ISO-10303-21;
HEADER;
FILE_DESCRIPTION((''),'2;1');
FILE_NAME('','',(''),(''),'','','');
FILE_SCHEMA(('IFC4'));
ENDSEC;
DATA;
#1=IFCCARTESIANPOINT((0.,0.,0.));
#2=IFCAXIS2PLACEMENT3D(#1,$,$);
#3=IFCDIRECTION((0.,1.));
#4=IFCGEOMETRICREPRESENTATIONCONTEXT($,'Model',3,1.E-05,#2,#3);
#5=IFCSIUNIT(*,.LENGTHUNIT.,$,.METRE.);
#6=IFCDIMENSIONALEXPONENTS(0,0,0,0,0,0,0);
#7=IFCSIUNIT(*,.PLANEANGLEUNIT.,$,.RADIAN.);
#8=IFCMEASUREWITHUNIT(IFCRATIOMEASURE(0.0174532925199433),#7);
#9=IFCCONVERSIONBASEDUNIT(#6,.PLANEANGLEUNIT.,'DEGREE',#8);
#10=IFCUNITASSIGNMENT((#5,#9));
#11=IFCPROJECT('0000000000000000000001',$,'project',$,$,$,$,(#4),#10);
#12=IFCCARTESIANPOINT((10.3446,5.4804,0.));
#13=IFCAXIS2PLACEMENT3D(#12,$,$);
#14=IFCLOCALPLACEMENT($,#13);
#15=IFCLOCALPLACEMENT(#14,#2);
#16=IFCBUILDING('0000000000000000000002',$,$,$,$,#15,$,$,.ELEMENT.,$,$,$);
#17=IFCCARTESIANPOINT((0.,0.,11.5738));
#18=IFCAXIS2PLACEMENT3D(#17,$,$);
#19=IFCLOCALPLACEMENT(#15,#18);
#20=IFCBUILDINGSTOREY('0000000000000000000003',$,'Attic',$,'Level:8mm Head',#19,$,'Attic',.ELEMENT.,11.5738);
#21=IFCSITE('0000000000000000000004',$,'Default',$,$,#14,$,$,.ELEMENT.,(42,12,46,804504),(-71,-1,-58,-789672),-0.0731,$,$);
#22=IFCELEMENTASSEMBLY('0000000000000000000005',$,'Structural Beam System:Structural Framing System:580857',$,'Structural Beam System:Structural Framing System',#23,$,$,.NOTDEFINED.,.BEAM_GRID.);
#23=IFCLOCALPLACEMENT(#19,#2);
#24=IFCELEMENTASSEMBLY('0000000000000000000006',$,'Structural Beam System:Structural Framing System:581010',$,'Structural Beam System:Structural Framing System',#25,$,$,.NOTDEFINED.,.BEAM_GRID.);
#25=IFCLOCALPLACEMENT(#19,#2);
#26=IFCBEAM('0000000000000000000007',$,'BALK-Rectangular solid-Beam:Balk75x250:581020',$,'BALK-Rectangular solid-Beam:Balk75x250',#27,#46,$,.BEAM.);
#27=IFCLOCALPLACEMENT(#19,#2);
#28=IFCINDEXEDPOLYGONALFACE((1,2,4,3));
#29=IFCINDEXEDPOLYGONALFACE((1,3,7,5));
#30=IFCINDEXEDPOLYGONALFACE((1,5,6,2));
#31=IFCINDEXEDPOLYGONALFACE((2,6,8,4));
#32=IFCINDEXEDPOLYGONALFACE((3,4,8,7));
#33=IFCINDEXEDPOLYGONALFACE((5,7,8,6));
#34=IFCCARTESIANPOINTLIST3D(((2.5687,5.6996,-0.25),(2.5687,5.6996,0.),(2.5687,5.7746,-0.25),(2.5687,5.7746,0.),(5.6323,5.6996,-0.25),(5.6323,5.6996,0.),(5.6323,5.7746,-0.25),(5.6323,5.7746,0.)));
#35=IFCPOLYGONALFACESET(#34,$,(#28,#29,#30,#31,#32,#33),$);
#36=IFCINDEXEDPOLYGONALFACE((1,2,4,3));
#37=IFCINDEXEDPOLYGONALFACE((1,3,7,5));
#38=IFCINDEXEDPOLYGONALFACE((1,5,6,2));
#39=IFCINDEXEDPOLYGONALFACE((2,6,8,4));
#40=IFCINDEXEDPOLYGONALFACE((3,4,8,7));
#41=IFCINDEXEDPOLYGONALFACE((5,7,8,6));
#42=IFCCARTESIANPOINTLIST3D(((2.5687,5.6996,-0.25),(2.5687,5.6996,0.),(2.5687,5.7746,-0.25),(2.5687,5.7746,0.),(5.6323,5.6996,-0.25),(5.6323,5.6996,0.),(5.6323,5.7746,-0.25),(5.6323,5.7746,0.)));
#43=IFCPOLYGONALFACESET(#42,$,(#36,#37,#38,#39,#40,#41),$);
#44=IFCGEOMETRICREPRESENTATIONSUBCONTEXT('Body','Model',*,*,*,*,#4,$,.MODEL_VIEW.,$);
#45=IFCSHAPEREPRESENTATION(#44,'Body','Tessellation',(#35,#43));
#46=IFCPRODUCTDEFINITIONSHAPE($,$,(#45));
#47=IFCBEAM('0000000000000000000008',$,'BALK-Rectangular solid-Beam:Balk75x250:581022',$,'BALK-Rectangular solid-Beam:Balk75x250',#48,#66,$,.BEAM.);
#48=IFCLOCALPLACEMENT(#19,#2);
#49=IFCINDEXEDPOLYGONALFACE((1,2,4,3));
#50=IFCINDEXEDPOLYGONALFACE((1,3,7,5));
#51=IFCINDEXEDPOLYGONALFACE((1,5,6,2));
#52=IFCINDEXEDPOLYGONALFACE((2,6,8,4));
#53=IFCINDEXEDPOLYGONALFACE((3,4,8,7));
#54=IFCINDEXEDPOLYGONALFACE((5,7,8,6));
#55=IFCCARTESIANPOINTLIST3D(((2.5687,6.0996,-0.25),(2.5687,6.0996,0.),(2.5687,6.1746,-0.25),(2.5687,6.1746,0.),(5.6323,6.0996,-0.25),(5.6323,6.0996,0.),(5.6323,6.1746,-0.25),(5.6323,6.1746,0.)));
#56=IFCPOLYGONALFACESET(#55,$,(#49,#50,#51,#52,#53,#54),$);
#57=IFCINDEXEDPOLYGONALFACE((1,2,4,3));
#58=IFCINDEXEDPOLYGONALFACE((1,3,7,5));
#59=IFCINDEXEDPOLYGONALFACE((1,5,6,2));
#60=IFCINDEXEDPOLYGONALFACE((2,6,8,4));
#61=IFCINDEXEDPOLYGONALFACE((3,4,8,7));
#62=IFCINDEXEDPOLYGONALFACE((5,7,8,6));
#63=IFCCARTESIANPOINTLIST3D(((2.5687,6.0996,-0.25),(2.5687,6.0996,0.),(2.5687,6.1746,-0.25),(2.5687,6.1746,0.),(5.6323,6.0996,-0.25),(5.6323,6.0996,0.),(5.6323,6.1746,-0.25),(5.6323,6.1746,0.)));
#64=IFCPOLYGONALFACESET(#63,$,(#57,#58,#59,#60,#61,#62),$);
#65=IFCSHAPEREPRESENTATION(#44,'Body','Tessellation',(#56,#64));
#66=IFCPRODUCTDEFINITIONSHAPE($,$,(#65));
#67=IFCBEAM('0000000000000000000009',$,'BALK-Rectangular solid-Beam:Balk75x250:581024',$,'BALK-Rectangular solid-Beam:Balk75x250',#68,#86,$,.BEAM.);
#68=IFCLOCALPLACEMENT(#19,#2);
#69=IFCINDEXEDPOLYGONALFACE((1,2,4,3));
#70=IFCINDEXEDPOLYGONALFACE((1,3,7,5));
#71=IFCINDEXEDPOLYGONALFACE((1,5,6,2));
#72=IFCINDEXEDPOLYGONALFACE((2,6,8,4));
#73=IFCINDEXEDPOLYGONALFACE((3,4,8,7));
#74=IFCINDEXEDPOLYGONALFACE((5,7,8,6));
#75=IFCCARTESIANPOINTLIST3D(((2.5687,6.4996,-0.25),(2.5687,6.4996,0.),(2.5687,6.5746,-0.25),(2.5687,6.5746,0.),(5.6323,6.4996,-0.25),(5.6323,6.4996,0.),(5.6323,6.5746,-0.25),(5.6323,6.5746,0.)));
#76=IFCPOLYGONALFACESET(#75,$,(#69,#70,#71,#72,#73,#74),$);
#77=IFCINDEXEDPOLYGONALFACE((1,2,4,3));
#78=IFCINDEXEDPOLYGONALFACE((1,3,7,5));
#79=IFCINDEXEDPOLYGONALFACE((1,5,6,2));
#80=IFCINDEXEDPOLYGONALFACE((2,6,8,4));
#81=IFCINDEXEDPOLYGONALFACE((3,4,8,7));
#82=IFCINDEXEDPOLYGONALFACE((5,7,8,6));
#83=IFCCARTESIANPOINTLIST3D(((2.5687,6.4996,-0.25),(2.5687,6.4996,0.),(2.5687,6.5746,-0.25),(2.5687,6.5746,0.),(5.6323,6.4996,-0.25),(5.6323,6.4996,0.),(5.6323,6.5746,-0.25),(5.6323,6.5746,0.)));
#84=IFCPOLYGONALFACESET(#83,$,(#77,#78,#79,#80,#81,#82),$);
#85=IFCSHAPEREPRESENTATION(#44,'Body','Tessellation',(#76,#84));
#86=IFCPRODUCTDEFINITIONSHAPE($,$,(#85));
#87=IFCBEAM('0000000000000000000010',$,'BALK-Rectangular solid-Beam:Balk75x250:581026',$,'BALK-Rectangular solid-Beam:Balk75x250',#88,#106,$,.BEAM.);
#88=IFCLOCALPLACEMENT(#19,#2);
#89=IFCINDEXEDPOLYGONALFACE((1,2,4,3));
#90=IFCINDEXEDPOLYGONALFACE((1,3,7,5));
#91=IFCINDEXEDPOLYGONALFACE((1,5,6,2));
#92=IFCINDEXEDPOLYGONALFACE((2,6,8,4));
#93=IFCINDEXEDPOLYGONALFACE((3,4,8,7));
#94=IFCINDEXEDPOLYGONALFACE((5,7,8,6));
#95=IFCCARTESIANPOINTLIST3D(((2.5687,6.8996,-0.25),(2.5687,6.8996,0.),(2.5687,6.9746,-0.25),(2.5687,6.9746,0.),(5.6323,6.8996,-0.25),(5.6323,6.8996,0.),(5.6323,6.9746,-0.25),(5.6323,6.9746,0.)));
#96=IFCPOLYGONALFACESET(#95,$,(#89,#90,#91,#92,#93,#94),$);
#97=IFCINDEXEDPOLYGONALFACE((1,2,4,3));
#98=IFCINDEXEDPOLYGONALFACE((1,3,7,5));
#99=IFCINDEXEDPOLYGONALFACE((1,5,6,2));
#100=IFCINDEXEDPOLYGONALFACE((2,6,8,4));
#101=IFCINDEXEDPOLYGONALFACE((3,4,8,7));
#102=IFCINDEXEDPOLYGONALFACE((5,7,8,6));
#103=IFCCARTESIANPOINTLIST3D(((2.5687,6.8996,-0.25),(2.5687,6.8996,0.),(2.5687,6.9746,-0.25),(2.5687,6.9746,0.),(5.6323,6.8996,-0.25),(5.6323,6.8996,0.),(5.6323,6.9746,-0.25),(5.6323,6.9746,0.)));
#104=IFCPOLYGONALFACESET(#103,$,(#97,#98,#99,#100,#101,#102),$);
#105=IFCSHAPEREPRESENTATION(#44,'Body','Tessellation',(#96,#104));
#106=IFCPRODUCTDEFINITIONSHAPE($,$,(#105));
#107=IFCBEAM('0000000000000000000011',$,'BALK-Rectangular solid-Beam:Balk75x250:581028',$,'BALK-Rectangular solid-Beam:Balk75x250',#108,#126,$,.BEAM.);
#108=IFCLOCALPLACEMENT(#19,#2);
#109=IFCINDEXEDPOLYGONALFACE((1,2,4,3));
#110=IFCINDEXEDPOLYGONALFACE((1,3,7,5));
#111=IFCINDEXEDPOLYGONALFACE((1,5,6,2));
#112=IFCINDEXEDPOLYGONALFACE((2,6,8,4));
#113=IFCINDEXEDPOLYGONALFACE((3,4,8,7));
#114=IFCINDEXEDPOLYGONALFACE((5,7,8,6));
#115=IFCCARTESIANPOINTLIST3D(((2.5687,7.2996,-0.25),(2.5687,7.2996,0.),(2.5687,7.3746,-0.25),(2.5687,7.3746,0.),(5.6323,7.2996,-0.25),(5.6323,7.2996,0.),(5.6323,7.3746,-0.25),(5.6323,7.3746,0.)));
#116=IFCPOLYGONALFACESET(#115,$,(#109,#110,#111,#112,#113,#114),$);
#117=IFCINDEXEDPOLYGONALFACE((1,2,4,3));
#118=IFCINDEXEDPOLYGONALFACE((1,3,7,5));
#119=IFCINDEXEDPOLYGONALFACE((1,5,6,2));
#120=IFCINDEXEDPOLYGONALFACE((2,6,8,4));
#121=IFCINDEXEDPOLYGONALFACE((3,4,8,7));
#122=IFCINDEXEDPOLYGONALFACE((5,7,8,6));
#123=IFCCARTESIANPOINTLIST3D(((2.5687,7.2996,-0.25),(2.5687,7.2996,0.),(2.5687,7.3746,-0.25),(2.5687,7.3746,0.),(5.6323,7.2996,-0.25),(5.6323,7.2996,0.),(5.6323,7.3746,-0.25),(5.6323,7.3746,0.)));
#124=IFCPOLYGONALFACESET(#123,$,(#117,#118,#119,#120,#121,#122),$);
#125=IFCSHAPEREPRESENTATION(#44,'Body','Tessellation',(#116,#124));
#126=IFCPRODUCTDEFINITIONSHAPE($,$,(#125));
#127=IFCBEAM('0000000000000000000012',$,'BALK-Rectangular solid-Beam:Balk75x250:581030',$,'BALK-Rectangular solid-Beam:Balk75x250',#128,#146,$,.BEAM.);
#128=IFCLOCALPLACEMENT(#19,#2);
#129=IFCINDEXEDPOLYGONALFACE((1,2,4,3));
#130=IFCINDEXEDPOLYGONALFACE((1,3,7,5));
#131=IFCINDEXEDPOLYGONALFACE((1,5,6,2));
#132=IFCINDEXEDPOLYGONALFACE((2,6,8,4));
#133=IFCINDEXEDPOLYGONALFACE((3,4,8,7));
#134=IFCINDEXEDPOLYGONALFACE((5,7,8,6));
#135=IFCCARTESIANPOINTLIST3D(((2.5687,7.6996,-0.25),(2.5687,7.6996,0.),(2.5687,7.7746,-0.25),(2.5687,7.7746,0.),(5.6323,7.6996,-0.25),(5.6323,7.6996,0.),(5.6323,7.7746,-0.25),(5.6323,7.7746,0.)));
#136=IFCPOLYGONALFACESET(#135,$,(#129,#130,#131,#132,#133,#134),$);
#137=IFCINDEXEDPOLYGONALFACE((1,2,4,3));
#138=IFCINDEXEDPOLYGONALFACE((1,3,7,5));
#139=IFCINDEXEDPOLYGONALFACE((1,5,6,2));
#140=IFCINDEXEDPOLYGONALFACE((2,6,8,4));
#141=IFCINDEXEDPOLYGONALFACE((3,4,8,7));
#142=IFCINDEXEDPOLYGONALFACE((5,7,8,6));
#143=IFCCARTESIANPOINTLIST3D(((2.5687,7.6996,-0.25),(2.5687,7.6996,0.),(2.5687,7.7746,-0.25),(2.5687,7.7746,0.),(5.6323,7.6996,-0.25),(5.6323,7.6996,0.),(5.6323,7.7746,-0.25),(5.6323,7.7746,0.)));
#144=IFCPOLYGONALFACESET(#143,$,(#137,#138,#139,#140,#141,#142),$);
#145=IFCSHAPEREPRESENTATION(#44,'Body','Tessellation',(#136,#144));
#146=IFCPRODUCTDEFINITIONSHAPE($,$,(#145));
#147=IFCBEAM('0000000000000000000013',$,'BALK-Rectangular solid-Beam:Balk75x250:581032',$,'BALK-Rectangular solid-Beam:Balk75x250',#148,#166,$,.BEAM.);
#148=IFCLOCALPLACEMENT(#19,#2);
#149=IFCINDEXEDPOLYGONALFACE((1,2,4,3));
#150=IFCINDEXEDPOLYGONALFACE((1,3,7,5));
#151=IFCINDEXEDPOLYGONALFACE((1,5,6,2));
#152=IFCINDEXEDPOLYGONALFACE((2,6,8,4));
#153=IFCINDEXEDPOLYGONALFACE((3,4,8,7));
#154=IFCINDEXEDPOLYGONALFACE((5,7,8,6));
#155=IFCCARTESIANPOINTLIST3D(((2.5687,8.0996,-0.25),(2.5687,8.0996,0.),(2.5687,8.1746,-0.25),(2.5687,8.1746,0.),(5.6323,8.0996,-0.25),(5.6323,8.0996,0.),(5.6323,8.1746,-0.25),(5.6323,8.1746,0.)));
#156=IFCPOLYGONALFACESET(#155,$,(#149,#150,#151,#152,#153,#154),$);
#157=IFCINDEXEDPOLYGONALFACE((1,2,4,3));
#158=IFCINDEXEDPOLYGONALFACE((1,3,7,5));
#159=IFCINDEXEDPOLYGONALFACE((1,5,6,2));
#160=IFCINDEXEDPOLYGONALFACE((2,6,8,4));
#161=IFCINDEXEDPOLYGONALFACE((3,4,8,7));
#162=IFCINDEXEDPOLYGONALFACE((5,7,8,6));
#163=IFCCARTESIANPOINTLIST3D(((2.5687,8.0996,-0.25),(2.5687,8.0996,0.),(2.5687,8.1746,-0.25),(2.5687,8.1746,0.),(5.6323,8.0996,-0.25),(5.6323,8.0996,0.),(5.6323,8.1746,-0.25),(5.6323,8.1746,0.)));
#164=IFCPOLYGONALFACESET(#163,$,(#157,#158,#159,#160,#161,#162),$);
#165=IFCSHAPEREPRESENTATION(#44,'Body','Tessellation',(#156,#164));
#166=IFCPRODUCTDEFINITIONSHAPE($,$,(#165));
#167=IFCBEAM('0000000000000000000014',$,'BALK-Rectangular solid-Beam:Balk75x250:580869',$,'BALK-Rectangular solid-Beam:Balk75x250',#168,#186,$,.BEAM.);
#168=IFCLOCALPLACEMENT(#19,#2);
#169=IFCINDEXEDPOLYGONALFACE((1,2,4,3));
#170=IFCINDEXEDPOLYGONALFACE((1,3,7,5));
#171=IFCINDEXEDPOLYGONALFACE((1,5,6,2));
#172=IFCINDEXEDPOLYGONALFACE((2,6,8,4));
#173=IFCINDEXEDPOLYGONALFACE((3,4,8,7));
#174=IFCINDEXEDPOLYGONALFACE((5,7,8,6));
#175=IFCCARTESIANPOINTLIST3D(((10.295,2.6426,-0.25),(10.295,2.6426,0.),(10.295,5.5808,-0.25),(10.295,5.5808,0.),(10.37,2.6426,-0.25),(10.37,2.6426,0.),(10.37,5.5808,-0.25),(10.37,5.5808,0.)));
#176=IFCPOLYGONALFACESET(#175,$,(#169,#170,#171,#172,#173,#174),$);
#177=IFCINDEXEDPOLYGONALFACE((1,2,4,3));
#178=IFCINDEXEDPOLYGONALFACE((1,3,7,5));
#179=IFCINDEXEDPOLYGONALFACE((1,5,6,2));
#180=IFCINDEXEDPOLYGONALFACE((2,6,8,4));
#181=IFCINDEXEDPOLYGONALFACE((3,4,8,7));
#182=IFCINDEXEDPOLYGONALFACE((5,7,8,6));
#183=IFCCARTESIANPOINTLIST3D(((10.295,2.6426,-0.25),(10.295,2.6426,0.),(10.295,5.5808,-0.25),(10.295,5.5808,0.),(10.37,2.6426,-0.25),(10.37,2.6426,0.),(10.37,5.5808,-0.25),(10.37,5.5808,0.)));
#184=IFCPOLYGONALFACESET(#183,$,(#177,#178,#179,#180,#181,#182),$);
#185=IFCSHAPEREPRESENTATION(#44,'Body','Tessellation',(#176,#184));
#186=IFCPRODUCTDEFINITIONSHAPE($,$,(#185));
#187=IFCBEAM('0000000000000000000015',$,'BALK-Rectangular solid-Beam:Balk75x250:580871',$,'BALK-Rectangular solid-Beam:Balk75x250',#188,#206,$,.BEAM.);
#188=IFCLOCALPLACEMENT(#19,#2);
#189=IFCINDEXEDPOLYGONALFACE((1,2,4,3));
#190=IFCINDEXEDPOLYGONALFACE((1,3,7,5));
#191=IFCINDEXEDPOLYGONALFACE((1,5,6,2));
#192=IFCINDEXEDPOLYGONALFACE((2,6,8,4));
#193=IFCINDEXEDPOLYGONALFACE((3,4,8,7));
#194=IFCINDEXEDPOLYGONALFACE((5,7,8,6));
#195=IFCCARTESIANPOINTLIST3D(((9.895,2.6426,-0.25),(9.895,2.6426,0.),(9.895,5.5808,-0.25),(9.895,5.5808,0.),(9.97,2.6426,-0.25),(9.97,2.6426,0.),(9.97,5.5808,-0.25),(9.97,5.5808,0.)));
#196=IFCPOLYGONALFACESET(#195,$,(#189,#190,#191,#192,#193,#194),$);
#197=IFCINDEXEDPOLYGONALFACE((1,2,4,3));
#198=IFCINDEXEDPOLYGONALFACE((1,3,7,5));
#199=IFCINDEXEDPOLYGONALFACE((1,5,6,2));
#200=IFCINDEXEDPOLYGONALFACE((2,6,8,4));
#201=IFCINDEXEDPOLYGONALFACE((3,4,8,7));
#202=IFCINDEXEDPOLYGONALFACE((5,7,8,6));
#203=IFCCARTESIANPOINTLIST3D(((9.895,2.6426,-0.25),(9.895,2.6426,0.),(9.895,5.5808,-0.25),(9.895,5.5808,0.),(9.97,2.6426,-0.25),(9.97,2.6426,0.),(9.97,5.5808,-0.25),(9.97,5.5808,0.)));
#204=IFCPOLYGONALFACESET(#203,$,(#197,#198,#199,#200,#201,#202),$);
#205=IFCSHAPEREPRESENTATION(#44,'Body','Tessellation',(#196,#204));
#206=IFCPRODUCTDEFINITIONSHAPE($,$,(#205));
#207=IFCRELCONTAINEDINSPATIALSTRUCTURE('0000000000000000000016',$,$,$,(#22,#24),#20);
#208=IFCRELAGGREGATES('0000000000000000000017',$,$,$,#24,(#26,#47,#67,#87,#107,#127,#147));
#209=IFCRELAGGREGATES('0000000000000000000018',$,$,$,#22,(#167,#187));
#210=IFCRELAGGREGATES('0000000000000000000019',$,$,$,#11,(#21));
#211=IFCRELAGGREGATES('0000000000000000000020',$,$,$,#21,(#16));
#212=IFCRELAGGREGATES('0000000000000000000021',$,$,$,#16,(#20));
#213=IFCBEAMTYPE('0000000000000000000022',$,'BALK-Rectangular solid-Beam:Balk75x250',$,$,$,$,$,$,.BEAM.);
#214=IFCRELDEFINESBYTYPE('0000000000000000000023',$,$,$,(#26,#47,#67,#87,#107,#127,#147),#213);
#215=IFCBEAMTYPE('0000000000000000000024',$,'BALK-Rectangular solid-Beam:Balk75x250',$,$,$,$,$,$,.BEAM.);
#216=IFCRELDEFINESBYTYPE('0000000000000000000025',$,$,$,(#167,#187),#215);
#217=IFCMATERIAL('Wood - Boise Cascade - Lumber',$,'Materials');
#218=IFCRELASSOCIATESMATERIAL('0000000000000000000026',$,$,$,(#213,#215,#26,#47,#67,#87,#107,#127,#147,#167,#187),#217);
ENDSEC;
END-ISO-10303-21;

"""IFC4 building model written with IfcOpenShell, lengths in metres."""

from ifc_helpers import new_model, entity, si_unit, converted_unit, direction, frame, frame_2d, origin, origin_2d_with_axis, place, context, subcontext, project, spatial, rectangle, extrude, source, transform, mapped, material, material_profile, profile_set, profile_usage, type_object, type_shapes, element, aggregate, save


model = new_model("IFC4")

# Units and contexts
model_context = context("Model", 3, precision=1e-05, world=origin(), true_north=direction((0.0, 1.0)))
body_context = subcontext(model_context, "Body", "Model", "MODEL_VIEW")
ifc_project = project(units=[si_unit("LENGTHUNIT", "METRE"), converted_unit("PLANEANGLEUNIT", "DEGREE", entity("IfcRatioMeasure", 0.0174532925199433), si_unit("PLANEANGLEUNIT", "RADIAN"), dimensions=[0, 0, 0, 0, 0, 0, 0])], contexts=[model_context])

# Site, building, storey
site_placement = place(None, frame((10.3446, 5.4804, 0.0)))
site = spatial("IfcSite", under=ifc_project, at=site_placement, Name="Default", CompositionType="ELEMENT", RefLatitude=(42, 12, 46, 804504), RefLongitude=(-71, -1, -58, -789672), RefElevation=-0.0731)
building_placement = place(site_placement, origin())
building = spatial("IfcBuilding", under=site, at=building_placement, CompositionType="ELEMENT")
storey_placement = place(building_placement, frame((0.0, 0.0, 11.5738)))
storey = spatial("IfcBuildingStorey", under=building, at=storey_placement, Name="Attic", ObjectType="Level:8mm Head", LongName="Attic", CompositionType="ELEMENT", Elevation=11.5738)

# Shared definitions
ifc_material = material(Name="Wood - Boise Cascade - Lumber", Category="Materials")
ifc_material_profile = material_profile(ifc_material, rectangle(XDim=0.25, YDim=0.075, at=frame_2d((0.0, 0.0), x_axis=(1.0, 0.0))), Name="Balk75x250")
ifc_profile_set = profile_set([ifc_material_profile], Name="Balk75x250")

# Element assembly
assembly_1_placement = place(storey_placement, origin())
assembly_1 = element("IfcElementAssembly", 1, at=assembly_1_placement, inside=storey, Name="Structural Beam System:Structural Framing System:580857", ObjectType="Structural Beam System:Structural Framing System", AssemblyPlace="NOTDEFINED", PredefinedType="BEAM_GRID")

# Element assembly, beams
assembly_2_placement = place(storey_placement, origin())
assembly_2 = element("IfcElementAssembly", 2, at=assembly_2_placement, inside=storey, Name="Structural Beam System:Structural Framing System:581010", ObjectType="Structural Beam System:Structural Framing System", AssemblyPlace="NOTDEFINED", PredefinedType="BEAM_GRID")
ifc_profile_usage_1 = profile_usage(ifc_profile_set, cardinal=8)
beam_type_1 = type_object("IfcBeamType", Name="BALK-Rectangular solid-Beam:Balk75x250", PredefinedType="BEAM", material=ifc_profile_set)
shared_shape_1 = source(origin(), body_context, "Body", "SweptSolid", [
    extrude(rectangle(XDim=0.25, YDim=0.075, at=origin_2d_with_axis()), frame((-1.6506, 0.0, 0.0), z_axis=(1.0, 0.0, 0.0), x_axis=(0.0, 0.0, -1.0)), (0.0, 0.0, 1.0), 3.0636),
    extrude(rectangle(XDim=0.25, YDim=0.075, at=origin_2d_with_axis()), frame((-1.6506, 0.0, 0.0), z_axis=(1.0, 0.0, 0.0), x_axis=(0.0, 0.0, -1.0)), (0.0, 0.0, 1.0), 3.0636),
])
type_shapes(beam_type_1, [shared_shape_1])
beam_1_placement = place(assembly_2_placement, frame((3.9817, 5.7371, -0.125), z_axis=(0.0, 0.0, 1.0), x_axis=(-1.0, 0.0, 0.0)))
beam_1 = element("IfcBeam", 3, at=beam_1_placement, type_object=beam_type_1, material=ifc_profile_usage_1, Name="BALK-Rectangular solid-Beam:Balk75x250:581020", ObjectType="BALK-Rectangular solid-Beam:Balk75x250", PredefinedType="BEAM", context=body_context, shape_type="MappedRepresentation", body=[
    mapped(shared_shape_1, transform((0.0, 0.0, 0.0), scale=1.0)),
])
ifc_profile_usage_2 = profile_usage(ifc_profile_set, cardinal=8)
beam_2_placement = place(assembly_2_placement, frame((3.9817, 6.1371, -0.125), z_axis=(0.0, 0.0, 1.0), x_axis=(-1.0, 0.0, 0.0)))
beam_2 = element("IfcBeam", 4, at=beam_2_placement, type_object=beam_type_1, material=ifc_profile_usage_2, Name="BALK-Rectangular solid-Beam:Balk75x250:581022", ObjectType="BALK-Rectangular solid-Beam:Balk75x250", PredefinedType="BEAM", context=body_context, shape_type="MappedRepresentation", body=[
    mapped(shared_shape_1, transform((0.0, 0.0, 0.0), scale=1.0)),
])
ifc_profile_usage_3 = profile_usage(ifc_profile_set, cardinal=8)
beam_3_placement = place(assembly_2_placement, frame((3.9817, 6.5371, -0.125), z_axis=(0.0, 0.0, 1.0), x_axis=(-1.0, 0.0, 0.0)))
beam_3 = element("IfcBeam", 5, at=beam_3_placement, type_object=beam_type_1, material=ifc_profile_usage_3, Name="BALK-Rectangular solid-Beam:Balk75x250:581024", ObjectType="BALK-Rectangular solid-Beam:Balk75x250", PredefinedType="BEAM", context=body_context, shape_type="MappedRepresentation", body=[
    mapped(shared_shape_1, transform((0.0, 0.0, 0.0), scale=1.0)),
])
ifc_profile_usage_4 = profile_usage(ifc_profile_set, cardinal=8)
beam_4_placement = place(assembly_2_placement, frame((3.9817, 6.9371, -0.125), z_axis=(0.0, 0.0, 1.0), x_axis=(-1.0, 0.0, 0.0)))
beam_4 = element("IfcBeam", 6, at=beam_4_placement, type_object=beam_type_1, material=ifc_profile_usage_4, Name="BALK-Rectangular solid-Beam:Balk75x250:581026", ObjectType="BALK-Rectangular solid-Beam:Balk75x250", PredefinedType="BEAM", context=body_context, shape_type="MappedRepresentation", body=[
    mapped(shared_shape_1, transform((0.0, 0.0, 0.0), scale=1.0)),
])
ifc_profile_usage_5 = profile_usage(ifc_profile_set, cardinal=8)
beam_5_placement = place(assembly_2_placement, frame((3.9817, 7.3371, -0.125), z_axis=(0.0, 0.0, 1.0), x_axis=(-1.0, 0.0, 0.0)))
beam_5 = element("IfcBeam", 7, at=beam_5_placement, type_object=beam_type_1, material=ifc_profile_usage_5, Name="BALK-Rectangular solid-Beam:Balk75x250:581028", ObjectType="BALK-Rectangular solid-Beam:Balk75x250", PredefinedType="BEAM", context=body_context, shape_type="MappedRepresentation", body=[
    mapped(shared_shape_1, transform((0.0, 0.0, 0.0), scale=1.0)),
])
ifc_profile_usage_6 = profile_usage(ifc_profile_set, cardinal=8)
beam_6_placement = place(assembly_2_placement, frame((3.9817, 7.7371, -0.125), z_axis=(0.0, 0.0, 1.0), x_axis=(-1.0, 0.0, 0.0)))
beam_6 = element("IfcBeam", 8, at=beam_6_placement, type_object=beam_type_1, material=ifc_profile_usage_6, Name="BALK-Rectangular solid-Beam:Balk75x250:581030", ObjectType="BALK-Rectangular solid-Beam:Balk75x250", PredefinedType="BEAM", context=body_context, shape_type="MappedRepresentation", body=[
    mapped(shared_shape_1, transform((0.0, 0.0, 0.0), scale=1.0)),
])
ifc_profile_usage_7 = profile_usage(ifc_profile_set, cardinal=8)
beam_7_placement = place(assembly_2_placement, frame((3.9817, 8.1371, -0.125), z_axis=(0.0, 0.0, 1.0), x_axis=(-1.0, 0.0, 0.0)))
beam_7 = element("IfcBeam", 9, at=beam_7_placement, type_object=beam_type_1, material=ifc_profile_usage_7, Name="BALK-Rectangular solid-Beam:Balk75x250:581032", ObjectType="BALK-Rectangular solid-Beam:Balk75x250", PredefinedType="BEAM", context=body_context, shape_type="MappedRepresentation", body=[
    mapped(shared_shape_1, transform((0.0, 0.0, 0.0), scale=1.0)),
])
aggregate(assembly_2, [beam_1, beam_2, beam_3, beam_4, beam_5, beam_6, beam_7])

# Beams
ifc_profile_usage_8 = profile_usage(ifc_profile_set, cardinal=8)
beam_type_2 = type_object("IfcBeamType", Name="BALK-Rectangular solid-Beam:Balk75x250", PredefinedType="BEAM", material=ifc_profile_set)
shared_shape_2 = source(origin(), body_context, "Body", "SweptSolid", [
    extrude(rectangle(XDim=0.25, YDim=0.075, at=origin_2d_with_axis()), frame((-1.4566, 0.0, 0.0), z_axis=(1.0, 0.0, 0.0), x_axis=(0.0, 0.0, -1.0)), (0.0, 0.0, 1.0), 2.9382),
    extrude(rectangle(XDim=0.25, YDim=0.075, at=origin_2d_with_axis()), frame((-1.4566, 0.0, 0.0), z_axis=(1.0, 0.0, 0.0), x_axis=(0.0, 0.0, -1.0)), (0.0, 0.0, 1.0), 2.9382),
])
type_shapes(beam_type_2, [shared_shape_2])
beam_8_placement = place(assembly_1_placement, frame((10.3325, 4.1242, -0.125), z_axis=(0.0, 0.0, 1.0), x_axis=(0.0, -1.0, 0.0)))
beam_8 = element("IfcBeam", 10, at=beam_8_placement, type_object=beam_type_2, material=ifc_profile_usage_8, Name="BALK-Rectangular solid-Beam:Balk75x250:580869", ObjectType="BALK-Rectangular solid-Beam:Balk75x250", PredefinedType="BEAM", context=body_context, shape_type="MappedRepresentation", body=[
    mapped(shared_shape_2, transform((0.0, 0.0, 0.0), scale=1.0)),
])
ifc_profile_usage_9 = profile_usage(ifc_profile_set, cardinal=8)
beam_9_placement = place(assembly_1_placement, frame((9.9325, 4.1242, -0.125), z_axis=(0.0, 0.0, 1.0), x_axis=(0.0, -1.0, 0.0)))
beam_9 = element("IfcBeam", 11, at=beam_9_placement, type_object=beam_type_2, material=ifc_profile_usage_9, Name="BALK-Rectangular solid-Beam:Balk75x250:580871", ObjectType="BALK-Rectangular solid-Beam:Balk75x250", PredefinedType="BEAM", context=body_context, shape_type="MappedRepresentation", body=[
    mapped(shared_shape_2, transform((0.0, 0.0, 0.0), scale=1.0)),
])
aggregate(assembly_1, [beam_8, beam_9])

save(model, "model.ifc")
